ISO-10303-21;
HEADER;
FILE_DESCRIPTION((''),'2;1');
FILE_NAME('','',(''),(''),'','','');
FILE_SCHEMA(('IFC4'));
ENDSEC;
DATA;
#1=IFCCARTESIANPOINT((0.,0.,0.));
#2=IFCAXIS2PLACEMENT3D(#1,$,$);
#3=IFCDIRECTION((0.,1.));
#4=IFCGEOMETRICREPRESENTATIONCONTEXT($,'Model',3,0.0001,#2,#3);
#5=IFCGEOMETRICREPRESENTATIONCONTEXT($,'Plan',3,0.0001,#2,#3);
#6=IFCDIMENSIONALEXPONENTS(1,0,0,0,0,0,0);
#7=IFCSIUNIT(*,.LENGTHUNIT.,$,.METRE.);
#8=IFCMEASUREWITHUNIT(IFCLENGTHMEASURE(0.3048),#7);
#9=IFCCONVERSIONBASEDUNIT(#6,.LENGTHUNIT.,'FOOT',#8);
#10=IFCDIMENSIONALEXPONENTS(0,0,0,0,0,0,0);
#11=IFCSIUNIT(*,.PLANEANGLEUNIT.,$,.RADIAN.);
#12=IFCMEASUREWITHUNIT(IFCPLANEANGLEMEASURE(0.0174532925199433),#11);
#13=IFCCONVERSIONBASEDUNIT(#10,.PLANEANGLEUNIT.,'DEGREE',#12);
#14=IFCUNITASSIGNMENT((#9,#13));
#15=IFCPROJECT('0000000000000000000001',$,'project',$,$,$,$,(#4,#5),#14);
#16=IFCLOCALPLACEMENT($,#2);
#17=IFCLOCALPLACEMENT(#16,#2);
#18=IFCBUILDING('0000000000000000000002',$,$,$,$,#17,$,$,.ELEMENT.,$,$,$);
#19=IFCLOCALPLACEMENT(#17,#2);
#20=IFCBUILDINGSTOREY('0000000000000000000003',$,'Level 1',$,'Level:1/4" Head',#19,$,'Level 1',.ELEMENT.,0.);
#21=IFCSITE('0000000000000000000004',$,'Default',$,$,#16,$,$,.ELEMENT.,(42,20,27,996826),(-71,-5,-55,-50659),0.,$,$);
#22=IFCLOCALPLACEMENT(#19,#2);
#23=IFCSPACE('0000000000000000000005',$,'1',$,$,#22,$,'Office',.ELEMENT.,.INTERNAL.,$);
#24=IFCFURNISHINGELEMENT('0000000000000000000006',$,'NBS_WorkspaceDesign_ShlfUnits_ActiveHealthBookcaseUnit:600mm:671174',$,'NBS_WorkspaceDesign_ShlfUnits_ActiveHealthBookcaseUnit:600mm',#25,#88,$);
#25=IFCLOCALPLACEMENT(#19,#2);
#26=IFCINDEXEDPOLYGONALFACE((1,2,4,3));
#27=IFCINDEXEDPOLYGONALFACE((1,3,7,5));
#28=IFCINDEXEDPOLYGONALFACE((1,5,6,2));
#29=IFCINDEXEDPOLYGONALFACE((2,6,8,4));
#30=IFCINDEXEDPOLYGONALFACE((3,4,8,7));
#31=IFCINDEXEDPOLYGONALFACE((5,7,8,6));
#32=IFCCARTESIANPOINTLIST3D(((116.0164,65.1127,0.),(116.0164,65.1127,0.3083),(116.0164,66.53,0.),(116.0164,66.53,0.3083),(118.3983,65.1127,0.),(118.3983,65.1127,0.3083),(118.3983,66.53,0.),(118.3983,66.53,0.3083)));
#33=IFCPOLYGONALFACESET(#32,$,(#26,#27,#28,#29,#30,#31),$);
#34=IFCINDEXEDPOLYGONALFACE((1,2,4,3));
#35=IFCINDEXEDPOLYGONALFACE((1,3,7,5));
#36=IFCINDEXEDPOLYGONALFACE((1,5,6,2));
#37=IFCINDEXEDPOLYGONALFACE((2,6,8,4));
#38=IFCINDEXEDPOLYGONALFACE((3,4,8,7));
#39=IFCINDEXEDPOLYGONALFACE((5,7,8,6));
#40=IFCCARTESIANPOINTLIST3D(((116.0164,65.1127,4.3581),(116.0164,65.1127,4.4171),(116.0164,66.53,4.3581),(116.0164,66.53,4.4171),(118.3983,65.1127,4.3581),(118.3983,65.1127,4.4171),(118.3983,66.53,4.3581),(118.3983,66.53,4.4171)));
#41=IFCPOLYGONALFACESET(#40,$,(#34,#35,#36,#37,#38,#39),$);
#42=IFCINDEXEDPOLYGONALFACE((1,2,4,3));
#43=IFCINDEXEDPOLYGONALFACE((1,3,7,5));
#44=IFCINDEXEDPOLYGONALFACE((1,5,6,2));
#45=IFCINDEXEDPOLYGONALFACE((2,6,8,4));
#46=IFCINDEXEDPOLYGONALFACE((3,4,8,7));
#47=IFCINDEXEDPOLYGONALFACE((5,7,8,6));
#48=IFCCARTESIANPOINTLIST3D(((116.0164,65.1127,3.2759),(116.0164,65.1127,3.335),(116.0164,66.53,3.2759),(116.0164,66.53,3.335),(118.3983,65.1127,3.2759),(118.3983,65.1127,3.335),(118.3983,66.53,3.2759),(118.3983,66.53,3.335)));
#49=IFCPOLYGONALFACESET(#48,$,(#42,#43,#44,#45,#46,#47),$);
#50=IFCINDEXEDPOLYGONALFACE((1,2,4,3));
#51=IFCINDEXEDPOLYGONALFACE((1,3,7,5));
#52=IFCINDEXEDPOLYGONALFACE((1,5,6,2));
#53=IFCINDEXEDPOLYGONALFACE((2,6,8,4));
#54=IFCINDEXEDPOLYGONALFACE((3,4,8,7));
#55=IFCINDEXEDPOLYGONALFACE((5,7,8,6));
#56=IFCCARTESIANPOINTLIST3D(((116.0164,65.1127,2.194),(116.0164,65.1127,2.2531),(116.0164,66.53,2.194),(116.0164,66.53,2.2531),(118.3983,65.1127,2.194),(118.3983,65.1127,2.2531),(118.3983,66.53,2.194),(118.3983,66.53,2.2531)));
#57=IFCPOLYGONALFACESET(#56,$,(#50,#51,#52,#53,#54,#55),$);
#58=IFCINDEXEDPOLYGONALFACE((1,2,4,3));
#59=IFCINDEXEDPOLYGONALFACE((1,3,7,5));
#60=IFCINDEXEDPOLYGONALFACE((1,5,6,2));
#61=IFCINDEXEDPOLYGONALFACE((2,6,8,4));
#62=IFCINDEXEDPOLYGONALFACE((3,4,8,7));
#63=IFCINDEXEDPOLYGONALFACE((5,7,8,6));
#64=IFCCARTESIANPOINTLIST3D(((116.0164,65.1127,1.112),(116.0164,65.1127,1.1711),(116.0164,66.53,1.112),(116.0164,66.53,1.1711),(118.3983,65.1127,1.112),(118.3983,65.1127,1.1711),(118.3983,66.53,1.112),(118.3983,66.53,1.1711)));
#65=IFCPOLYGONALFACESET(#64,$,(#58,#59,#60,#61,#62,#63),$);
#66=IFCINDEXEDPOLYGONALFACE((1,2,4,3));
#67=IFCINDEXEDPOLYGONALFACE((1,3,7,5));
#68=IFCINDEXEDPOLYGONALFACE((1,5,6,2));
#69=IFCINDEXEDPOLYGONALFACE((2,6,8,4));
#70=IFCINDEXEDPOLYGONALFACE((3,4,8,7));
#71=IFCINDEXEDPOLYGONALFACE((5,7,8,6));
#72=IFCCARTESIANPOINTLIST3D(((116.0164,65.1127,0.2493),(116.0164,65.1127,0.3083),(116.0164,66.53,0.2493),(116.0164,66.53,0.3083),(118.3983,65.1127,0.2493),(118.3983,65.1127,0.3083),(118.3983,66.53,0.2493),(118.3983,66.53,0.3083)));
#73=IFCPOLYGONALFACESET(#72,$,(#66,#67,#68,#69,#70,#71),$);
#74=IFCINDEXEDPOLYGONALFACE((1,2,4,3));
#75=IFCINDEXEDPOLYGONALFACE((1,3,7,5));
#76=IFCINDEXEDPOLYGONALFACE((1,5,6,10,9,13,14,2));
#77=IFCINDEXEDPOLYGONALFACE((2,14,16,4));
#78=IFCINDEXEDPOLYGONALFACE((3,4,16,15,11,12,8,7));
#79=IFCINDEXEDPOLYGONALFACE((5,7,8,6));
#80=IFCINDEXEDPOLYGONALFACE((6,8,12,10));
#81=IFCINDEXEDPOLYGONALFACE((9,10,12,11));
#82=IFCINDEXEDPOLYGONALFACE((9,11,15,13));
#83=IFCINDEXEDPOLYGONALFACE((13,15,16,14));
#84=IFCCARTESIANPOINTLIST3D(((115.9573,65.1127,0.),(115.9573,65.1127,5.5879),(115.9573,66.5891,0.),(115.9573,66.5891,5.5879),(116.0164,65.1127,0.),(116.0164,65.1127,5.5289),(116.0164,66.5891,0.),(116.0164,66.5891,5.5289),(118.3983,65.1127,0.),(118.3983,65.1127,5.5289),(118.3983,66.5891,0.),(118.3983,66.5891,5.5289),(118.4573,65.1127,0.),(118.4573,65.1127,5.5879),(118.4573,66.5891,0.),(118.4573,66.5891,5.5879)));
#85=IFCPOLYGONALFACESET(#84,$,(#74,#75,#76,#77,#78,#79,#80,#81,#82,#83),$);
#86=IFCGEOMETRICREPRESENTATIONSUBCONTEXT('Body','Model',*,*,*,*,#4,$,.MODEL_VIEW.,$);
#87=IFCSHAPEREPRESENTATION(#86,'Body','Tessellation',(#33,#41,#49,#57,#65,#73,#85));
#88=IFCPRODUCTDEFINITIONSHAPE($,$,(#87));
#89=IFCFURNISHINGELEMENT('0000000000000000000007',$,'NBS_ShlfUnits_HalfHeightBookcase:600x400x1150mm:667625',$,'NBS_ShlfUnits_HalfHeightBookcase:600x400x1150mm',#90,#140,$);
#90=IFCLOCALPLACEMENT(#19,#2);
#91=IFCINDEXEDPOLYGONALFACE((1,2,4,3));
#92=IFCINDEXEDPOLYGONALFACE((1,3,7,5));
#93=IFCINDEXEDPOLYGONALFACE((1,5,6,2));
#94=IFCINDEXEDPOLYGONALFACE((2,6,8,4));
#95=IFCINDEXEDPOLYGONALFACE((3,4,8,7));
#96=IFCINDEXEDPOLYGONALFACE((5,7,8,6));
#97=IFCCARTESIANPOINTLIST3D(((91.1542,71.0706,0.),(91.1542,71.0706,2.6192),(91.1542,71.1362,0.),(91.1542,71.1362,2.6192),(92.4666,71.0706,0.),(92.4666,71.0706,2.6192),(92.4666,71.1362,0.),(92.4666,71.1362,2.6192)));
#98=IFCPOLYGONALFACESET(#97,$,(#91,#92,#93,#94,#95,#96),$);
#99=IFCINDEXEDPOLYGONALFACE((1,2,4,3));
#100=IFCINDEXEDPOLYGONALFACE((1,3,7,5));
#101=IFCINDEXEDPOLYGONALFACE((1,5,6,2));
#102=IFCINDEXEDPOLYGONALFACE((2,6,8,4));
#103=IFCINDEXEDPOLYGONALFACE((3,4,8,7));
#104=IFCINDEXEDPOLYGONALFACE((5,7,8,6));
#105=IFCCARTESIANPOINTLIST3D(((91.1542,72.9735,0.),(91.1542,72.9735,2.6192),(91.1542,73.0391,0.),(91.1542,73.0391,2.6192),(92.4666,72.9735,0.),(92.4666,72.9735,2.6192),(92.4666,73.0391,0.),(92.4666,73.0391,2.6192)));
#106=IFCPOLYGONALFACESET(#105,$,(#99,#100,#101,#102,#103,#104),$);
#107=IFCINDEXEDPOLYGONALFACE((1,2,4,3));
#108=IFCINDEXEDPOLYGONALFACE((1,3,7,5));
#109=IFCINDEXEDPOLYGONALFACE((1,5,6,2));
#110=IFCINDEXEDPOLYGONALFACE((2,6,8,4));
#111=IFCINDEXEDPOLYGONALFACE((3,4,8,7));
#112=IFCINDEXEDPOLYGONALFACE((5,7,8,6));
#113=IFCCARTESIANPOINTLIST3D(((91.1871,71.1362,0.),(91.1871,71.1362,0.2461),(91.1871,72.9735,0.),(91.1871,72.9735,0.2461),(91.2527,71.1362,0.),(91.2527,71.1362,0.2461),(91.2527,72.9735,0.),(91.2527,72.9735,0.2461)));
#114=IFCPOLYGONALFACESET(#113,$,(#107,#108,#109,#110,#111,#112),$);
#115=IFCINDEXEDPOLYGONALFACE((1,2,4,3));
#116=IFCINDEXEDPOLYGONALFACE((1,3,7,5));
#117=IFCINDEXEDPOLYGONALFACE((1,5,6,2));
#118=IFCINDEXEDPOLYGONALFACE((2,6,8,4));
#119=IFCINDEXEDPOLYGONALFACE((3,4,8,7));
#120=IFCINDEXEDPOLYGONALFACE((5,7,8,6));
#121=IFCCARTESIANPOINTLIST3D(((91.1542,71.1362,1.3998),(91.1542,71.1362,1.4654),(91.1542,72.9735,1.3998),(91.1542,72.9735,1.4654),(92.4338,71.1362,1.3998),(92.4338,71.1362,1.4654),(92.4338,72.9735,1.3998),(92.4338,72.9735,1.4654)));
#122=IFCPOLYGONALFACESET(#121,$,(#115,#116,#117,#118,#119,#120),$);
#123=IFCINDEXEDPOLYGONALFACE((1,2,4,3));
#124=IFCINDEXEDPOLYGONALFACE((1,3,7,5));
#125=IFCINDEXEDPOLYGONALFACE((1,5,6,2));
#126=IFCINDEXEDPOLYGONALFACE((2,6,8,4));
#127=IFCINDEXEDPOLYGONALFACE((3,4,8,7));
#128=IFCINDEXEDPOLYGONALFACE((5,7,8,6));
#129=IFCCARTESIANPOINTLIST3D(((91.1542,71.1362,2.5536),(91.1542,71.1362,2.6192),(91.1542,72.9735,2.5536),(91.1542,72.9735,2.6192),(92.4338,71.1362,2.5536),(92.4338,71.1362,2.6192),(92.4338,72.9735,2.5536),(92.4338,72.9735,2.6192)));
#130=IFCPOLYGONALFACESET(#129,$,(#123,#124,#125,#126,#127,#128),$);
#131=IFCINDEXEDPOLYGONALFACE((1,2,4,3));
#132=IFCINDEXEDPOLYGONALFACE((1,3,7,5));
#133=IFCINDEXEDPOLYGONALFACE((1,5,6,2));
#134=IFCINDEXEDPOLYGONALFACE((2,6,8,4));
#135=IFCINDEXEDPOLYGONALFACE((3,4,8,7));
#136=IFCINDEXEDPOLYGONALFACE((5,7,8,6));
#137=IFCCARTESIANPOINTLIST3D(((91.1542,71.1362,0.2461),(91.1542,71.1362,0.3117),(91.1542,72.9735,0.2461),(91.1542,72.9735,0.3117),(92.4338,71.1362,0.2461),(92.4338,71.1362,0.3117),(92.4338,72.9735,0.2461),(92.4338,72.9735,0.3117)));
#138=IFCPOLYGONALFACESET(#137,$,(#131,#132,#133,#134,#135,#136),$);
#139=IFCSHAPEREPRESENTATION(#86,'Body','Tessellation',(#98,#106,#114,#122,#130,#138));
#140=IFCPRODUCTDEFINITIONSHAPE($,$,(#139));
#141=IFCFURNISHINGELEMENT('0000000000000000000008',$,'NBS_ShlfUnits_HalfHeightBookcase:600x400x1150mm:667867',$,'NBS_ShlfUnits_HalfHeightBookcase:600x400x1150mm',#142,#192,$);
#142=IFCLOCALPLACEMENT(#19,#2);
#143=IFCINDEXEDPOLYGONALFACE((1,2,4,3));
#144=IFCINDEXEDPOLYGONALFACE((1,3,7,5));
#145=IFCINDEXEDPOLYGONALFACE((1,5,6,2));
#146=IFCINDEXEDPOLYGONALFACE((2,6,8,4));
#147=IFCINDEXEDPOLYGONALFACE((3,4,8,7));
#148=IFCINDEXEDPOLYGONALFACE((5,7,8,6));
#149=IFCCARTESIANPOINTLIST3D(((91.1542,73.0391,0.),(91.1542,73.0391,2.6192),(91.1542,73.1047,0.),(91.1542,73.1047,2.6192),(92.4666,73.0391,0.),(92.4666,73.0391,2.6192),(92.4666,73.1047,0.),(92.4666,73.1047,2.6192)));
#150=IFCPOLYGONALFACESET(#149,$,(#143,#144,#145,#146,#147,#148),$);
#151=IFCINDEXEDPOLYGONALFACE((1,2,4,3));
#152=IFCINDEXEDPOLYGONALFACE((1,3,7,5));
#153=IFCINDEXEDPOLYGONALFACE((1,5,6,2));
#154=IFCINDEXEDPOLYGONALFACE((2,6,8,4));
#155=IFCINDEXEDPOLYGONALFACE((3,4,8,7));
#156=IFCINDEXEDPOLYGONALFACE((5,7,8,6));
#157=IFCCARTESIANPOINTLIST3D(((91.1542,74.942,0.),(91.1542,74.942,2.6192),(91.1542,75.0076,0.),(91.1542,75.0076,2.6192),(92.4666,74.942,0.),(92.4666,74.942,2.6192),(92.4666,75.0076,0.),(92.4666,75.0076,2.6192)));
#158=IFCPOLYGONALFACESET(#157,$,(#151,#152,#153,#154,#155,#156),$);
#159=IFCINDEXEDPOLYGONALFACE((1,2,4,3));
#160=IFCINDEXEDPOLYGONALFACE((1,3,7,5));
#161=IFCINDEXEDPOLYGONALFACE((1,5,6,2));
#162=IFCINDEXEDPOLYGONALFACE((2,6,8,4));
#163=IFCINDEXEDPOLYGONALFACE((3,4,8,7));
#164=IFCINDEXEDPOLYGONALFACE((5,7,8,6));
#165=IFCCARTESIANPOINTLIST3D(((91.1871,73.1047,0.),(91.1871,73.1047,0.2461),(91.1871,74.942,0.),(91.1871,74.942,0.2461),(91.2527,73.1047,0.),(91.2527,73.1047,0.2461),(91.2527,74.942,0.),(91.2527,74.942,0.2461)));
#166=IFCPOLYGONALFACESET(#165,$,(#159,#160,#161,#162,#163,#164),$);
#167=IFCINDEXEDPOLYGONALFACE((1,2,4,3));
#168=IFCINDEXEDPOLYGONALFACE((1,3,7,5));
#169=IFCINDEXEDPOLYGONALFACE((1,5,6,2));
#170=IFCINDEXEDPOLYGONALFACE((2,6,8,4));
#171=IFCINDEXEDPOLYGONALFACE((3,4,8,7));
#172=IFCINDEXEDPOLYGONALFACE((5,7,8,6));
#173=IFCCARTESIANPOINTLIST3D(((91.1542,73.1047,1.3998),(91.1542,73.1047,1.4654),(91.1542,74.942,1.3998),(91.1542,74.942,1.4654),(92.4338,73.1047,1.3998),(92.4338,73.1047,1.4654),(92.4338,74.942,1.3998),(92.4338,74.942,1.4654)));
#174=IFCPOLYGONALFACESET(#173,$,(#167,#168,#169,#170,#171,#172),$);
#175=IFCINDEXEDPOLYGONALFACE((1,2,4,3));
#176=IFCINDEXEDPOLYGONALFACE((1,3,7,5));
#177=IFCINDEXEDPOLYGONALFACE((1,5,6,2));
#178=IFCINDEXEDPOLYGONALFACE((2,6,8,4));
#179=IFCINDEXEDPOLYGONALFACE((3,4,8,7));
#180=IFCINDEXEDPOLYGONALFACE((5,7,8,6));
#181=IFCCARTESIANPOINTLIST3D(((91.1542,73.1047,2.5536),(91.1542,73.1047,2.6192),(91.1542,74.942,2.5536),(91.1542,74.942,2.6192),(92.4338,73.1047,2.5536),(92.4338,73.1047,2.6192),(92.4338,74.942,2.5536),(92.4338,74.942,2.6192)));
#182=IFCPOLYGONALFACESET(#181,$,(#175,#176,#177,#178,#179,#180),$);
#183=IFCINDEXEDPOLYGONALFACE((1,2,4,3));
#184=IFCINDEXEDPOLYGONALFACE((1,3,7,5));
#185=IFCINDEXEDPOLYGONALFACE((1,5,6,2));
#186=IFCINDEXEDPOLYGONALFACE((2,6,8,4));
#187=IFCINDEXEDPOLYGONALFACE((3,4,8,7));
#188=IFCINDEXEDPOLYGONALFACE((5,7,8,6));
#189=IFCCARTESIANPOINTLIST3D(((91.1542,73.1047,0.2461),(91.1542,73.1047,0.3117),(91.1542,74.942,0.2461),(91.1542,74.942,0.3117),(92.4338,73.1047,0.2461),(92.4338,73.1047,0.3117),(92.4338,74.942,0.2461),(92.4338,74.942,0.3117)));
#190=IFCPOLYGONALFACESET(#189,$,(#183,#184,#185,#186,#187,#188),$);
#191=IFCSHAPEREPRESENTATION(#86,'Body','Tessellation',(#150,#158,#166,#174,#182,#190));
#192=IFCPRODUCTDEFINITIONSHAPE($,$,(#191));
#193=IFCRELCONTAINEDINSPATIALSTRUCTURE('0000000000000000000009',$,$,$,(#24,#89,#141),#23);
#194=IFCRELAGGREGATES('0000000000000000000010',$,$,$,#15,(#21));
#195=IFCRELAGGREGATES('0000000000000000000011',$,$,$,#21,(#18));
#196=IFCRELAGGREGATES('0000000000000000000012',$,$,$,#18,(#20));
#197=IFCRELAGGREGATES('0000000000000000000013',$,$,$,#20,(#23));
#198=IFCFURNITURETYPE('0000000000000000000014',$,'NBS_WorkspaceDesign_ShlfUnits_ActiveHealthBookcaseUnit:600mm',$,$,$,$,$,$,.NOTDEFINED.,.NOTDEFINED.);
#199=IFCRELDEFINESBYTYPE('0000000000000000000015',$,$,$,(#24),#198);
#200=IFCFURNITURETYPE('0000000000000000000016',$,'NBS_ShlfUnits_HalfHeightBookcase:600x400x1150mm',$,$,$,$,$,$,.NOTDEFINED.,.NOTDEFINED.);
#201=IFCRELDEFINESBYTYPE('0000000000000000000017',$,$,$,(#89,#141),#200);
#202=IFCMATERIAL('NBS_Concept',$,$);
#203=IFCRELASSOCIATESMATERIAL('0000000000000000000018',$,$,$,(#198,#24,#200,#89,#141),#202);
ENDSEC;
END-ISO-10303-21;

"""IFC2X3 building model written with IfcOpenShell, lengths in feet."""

from ifc_helpers import new_model, entity, si_unit, converted_unit, direction, frame, frame_2d, origin, origin_2d_with_axis, place, context, subcontext, project, spatial, polyline, rectangle, outline, extrude, source, transform, mapped, material, type_object, type_shapes, element, save


model = new_model("IFC2X3")

# Units and contexts
model_context = context("Model", 3, precision=0.0001, world=origin(), true_north=direction((0.0, 1.0)))
plan_context = context("Plan", 3, precision=0.0001, world=origin(), true_north=direction((0.0, 1.0)))
body_context = subcontext(model_context, "Body", "Model", "MODEL_VIEW")
ifc_project = project(units=[converted_unit("LENGTHUNIT", "FOOT", entity("IfcLengthMeasure", 0.3048), si_unit("LENGTHUNIT", "METRE"), dimensions=[1, 0, 0, 0, 0, 0, 0]), converted_unit("PLANEANGLEUNIT", "DEGREE", entity("IfcPlaneAngleMeasure", 0.0174532925199433), si_unit("PLANEANGLEUNIT", "RADIAN"), dimensions=[0, 0, 0, 0, 0, 0, 0])], contexts=[model_context, plan_context])

# Site, building, storey
site_placement = place(None, origin())
site = spatial("IfcSite", under=ifc_project, at=site_placement, Name="Default", CompositionType="ELEMENT", RefLatitude=(42, 20, 27, 996826), RefLongitude=(-71, -5, -55, -50659), RefElevation=0.0)
building_placement = place(site_placement, origin())
building = spatial("IfcBuilding", under=site, at=building_placement, CompositionType="ELEMENT")
storey_placement = place(building_placement, origin())
storey = spatial("IfcBuildingStorey", under=building, at=storey_placement, Name="Level 1", ObjectType="Level:1/4\" Head", LongName="Level 1", CompositionType="ELEMENT", Elevation=0.0)

# Shared definitions
space_placement = place(storey_placement, origin())
space = spatial("IfcSpace", under=storey, at=space_placement, Name="1", LongName="Office", CompositionType="ELEMENT", InteriorOrExteriorSpace="INTERNAL")

# Furnishing elements
ifc_material_1 = material(Name="NBS_Concept")
furniture_type_1 = type_object("IfcFurnitureType", Name="NBS_WorkspaceDesign_ShlfUnits_ActiveHealthBookcaseUnit:600mm", AssemblyPlace="NOTDEFINED", material=ifc_material_1)
shared_shape_1 = source(origin(), body_context, "Body", "SweptSolid", [
    extrude(rectangle(XDim=1.4173, YDim=2.3819, at=frame_2d((0.0, 0.0), x_axis=(1.0, 0.0))), frame((0.0, -0.7677, 0.0), z_axis=(0.0, 0.0, 1.0), x_axis=(0.0, 1.0, 0.0)), (0.0, 0.0, 1.0), 0.3083),
    extrude(rectangle(XDim=1.4173, YDim=2.3819, at=frame_2d((0.0, 0.0), x_axis=(1.0, 0.0))), frame((0.0, -0.7677, 4.3581), z_axis=(0.0, 0.0, 1.0), x_axis=(0.0, 1.0, 0.0)), (0.0, 0.0, 1.0), 0.0591),
    extrude(rectangle(XDim=1.4173, YDim=2.3819, at=frame_2d((0.0, 0.0), x_axis=(1.0, 0.0))), frame((0.0, -0.7677, 3.2759), z_axis=(0.0, 0.0, 1.0), x_axis=(0.0, 1.0, 0.0)), (0.0, 0.0, 1.0), 0.0591),
    extrude(rectangle(XDim=1.4173, YDim=2.3819, at=frame_2d((0.0, 0.0), x_axis=(1.0, 0.0))), frame((0.0, -0.7677, 2.194), z_axis=(0.0, 0.0, 1.0), x_axis=(0.0, 1.0, 0.0)), (0.0, 0.0, 1.0), 0.0591),
    extrude(rectangle(XDim=1.4173, YDim=2.3819, at=frame_2d((0.0, 0.0), x_axis=(1.0, 0.0))), frame((0.0, -0.7677, 1.112), z_axis=(0.0, 0.0, 1.0), x_axis=(0.0, 1.0, 0.0)), (0.0, 0.0, 1.0), 0.0591),
    extrude(rectangle(XDim=1.4173, YDim=2.3819, at=frame_2d((0.0, 0.0), x_axis=(1.0, 0.0))), frame((0.0, -0.7677, 0.2493), z_axis=(0.0, 0.0, 1.0), x_axis=(0.0, 1.0, 0.0)), (0.0, 0.0, 1.0), 0.0591),
    extrude(outline(polyline([(-2.8087, -1.25), (2.7792, -1.25), (2.7792, -1.1909), (-2.7497, -1.1909), (-2.7497, 1.1909), (2.7792, 1.1909), (2.7792, 1.25), (-2.8087, 1.25), (-2.8087, -1.25)])), frame((0.0, -1.4764, 2.7792), z_axis=(0.0, 1.0, 0.0), x_axis=(0.0, 0.0, -1.0)), (0.0, 0.0, 1.0), 1.4764),
])
type_shapes(furniture_type_1, [shared_shape_1])
for number, where, name in (
    (1, (117.2073, 66.5891, 0.0), "NBS_WorkspaceDesign_ShlfUnits_ActiveHealthBookcaseUnit:600mm:671174"),
):
    element("IfcFurnishingElement", number, at=place(space_placement, frame(where)), inside=space, type_object=furniture_type_1, material=ifc_material_1, Name=name, ObjectType="NBS_WorkspaceDesign_ShlfUnits_ActiveHealthBookcaseUnit:600mm", context=body_context, shape_type="MappedRepresentation", body=[
        mapped(shared_shape_1, transform((0.0, 0.0, 0.0), scale=1.0)),
    ])
furniture_type_2 = type_object("IfcFurnitureType", Name="NBS_ShlfUnits_HalfHeightBookcase:600x400x1150mm", AssemblyPlace="NOTDEFINED", material=ifc_material_1)
shared_shape_2 = source(origin(), body_context, "Body", "SweptSolid", [
    extrude(rectangle(XDim=0.0656, YDim=1.3123, at=origin_2d_with_axis()), frame((0.9514, -0.6562, 0.0), z_axis=(0.0, 0.0, 1.0), x_axis=(-1.0, 0.0, 0.0)), (0.0, 0.0, 1.0), 2.6192),
    extrude(rectangle(XDim=0.0656, YDim=1.3123, at=origin_2d_with_axis()), frame((-0.9514, -0.6562, 0.0), z_axis=(0.0, 0.0, 1.0), x_axis=(-1.0, 0.0, 0.0)), (0.0, 0.0, 1.0), 2.6192),
    extrude(rectangle(XDim=1.8373, YDim=0.0656, at=origin_2d_with_axis()), frame((0.0, -1.2467, 0.0), z_axis=(0.0, 0.0, 1.0), x_axis=(-1.0, 0.0, 0.0)), (0.0, 0.0, 1.0), 0.2461),
    extrude(rectangle(XDim=1.2795, YDim=1.8373, at=frame_2d((0.0, 0.0), x_axis=(1.0, 0.0))), frame((0.0, -0.6726, 1.3998), z_axis=(0.0, 0.0, 1.0), x_axis=(0.0, 1.0, 0.0)), (0.0, 0.0, 1.0), 0.0656),
    extrude(rectangle(XDim=1.2795, YDim=1.8373, at=frame_2d((0.0, 0.0), x_axis=(1.0, 0.0))), frame((0.0, -0.6726, 2.5536), z_axis=(0.0, 0.0, 1.0), x_axis=(0.0, 1.0, 0.0)), (0.0, 0.0, 1.0), 0.0656),
    extrude(rectangle(XDim=1.2795, YDim=1.8373, at=frame_2d((0.0, 0.0), x_axis=(1.0, 0.0))), frame((0.0, -0.6726, 0.2461), z_axis=(0.0, 0.0, 1.0), x_axis=(0.0, 1.0, 0.0)), (0.0, 0.0, 1.0), 0.0656),
])
type_shapes(furniture_type_2, [shared_shape_2])
for number, where, z_axis, x_axis, name in (
    (2, (92.4666, 72.0549, 0.0), (0.0, 0.0, 1.0), (0.0, -1.0, 0.0), "NBS_ShlfUnits_HalfHeightBookcase:600x400x1150mm:667625"),
    (3, (92.4666, 74.0234, 0.0), (0.0, 0.0, 1.0), (0.0, -1.0, 0.0), "NBS_ShlfUnits_HalfHeightBookcase:600x400x1150mm:667867"),
):
    element("IfcFurnishingElement", number, at=place(space_placement, frame(where, z_axis=z_axis, x_axis=x_axis)), inside=space, type_object=furniture_type_2, material=ifc_material_1, Name=name, ObjectType="NBS_ShlfUnits_HalfHeightBookcase:600x400x1150mm", context=body_context, shape_type="MappedRepresentation", body=[
        mapped(shared_shape_2, transform((0.0, 0.0, 0.0), scale=1.0)),
    ])

save(model, "model.ifc")
